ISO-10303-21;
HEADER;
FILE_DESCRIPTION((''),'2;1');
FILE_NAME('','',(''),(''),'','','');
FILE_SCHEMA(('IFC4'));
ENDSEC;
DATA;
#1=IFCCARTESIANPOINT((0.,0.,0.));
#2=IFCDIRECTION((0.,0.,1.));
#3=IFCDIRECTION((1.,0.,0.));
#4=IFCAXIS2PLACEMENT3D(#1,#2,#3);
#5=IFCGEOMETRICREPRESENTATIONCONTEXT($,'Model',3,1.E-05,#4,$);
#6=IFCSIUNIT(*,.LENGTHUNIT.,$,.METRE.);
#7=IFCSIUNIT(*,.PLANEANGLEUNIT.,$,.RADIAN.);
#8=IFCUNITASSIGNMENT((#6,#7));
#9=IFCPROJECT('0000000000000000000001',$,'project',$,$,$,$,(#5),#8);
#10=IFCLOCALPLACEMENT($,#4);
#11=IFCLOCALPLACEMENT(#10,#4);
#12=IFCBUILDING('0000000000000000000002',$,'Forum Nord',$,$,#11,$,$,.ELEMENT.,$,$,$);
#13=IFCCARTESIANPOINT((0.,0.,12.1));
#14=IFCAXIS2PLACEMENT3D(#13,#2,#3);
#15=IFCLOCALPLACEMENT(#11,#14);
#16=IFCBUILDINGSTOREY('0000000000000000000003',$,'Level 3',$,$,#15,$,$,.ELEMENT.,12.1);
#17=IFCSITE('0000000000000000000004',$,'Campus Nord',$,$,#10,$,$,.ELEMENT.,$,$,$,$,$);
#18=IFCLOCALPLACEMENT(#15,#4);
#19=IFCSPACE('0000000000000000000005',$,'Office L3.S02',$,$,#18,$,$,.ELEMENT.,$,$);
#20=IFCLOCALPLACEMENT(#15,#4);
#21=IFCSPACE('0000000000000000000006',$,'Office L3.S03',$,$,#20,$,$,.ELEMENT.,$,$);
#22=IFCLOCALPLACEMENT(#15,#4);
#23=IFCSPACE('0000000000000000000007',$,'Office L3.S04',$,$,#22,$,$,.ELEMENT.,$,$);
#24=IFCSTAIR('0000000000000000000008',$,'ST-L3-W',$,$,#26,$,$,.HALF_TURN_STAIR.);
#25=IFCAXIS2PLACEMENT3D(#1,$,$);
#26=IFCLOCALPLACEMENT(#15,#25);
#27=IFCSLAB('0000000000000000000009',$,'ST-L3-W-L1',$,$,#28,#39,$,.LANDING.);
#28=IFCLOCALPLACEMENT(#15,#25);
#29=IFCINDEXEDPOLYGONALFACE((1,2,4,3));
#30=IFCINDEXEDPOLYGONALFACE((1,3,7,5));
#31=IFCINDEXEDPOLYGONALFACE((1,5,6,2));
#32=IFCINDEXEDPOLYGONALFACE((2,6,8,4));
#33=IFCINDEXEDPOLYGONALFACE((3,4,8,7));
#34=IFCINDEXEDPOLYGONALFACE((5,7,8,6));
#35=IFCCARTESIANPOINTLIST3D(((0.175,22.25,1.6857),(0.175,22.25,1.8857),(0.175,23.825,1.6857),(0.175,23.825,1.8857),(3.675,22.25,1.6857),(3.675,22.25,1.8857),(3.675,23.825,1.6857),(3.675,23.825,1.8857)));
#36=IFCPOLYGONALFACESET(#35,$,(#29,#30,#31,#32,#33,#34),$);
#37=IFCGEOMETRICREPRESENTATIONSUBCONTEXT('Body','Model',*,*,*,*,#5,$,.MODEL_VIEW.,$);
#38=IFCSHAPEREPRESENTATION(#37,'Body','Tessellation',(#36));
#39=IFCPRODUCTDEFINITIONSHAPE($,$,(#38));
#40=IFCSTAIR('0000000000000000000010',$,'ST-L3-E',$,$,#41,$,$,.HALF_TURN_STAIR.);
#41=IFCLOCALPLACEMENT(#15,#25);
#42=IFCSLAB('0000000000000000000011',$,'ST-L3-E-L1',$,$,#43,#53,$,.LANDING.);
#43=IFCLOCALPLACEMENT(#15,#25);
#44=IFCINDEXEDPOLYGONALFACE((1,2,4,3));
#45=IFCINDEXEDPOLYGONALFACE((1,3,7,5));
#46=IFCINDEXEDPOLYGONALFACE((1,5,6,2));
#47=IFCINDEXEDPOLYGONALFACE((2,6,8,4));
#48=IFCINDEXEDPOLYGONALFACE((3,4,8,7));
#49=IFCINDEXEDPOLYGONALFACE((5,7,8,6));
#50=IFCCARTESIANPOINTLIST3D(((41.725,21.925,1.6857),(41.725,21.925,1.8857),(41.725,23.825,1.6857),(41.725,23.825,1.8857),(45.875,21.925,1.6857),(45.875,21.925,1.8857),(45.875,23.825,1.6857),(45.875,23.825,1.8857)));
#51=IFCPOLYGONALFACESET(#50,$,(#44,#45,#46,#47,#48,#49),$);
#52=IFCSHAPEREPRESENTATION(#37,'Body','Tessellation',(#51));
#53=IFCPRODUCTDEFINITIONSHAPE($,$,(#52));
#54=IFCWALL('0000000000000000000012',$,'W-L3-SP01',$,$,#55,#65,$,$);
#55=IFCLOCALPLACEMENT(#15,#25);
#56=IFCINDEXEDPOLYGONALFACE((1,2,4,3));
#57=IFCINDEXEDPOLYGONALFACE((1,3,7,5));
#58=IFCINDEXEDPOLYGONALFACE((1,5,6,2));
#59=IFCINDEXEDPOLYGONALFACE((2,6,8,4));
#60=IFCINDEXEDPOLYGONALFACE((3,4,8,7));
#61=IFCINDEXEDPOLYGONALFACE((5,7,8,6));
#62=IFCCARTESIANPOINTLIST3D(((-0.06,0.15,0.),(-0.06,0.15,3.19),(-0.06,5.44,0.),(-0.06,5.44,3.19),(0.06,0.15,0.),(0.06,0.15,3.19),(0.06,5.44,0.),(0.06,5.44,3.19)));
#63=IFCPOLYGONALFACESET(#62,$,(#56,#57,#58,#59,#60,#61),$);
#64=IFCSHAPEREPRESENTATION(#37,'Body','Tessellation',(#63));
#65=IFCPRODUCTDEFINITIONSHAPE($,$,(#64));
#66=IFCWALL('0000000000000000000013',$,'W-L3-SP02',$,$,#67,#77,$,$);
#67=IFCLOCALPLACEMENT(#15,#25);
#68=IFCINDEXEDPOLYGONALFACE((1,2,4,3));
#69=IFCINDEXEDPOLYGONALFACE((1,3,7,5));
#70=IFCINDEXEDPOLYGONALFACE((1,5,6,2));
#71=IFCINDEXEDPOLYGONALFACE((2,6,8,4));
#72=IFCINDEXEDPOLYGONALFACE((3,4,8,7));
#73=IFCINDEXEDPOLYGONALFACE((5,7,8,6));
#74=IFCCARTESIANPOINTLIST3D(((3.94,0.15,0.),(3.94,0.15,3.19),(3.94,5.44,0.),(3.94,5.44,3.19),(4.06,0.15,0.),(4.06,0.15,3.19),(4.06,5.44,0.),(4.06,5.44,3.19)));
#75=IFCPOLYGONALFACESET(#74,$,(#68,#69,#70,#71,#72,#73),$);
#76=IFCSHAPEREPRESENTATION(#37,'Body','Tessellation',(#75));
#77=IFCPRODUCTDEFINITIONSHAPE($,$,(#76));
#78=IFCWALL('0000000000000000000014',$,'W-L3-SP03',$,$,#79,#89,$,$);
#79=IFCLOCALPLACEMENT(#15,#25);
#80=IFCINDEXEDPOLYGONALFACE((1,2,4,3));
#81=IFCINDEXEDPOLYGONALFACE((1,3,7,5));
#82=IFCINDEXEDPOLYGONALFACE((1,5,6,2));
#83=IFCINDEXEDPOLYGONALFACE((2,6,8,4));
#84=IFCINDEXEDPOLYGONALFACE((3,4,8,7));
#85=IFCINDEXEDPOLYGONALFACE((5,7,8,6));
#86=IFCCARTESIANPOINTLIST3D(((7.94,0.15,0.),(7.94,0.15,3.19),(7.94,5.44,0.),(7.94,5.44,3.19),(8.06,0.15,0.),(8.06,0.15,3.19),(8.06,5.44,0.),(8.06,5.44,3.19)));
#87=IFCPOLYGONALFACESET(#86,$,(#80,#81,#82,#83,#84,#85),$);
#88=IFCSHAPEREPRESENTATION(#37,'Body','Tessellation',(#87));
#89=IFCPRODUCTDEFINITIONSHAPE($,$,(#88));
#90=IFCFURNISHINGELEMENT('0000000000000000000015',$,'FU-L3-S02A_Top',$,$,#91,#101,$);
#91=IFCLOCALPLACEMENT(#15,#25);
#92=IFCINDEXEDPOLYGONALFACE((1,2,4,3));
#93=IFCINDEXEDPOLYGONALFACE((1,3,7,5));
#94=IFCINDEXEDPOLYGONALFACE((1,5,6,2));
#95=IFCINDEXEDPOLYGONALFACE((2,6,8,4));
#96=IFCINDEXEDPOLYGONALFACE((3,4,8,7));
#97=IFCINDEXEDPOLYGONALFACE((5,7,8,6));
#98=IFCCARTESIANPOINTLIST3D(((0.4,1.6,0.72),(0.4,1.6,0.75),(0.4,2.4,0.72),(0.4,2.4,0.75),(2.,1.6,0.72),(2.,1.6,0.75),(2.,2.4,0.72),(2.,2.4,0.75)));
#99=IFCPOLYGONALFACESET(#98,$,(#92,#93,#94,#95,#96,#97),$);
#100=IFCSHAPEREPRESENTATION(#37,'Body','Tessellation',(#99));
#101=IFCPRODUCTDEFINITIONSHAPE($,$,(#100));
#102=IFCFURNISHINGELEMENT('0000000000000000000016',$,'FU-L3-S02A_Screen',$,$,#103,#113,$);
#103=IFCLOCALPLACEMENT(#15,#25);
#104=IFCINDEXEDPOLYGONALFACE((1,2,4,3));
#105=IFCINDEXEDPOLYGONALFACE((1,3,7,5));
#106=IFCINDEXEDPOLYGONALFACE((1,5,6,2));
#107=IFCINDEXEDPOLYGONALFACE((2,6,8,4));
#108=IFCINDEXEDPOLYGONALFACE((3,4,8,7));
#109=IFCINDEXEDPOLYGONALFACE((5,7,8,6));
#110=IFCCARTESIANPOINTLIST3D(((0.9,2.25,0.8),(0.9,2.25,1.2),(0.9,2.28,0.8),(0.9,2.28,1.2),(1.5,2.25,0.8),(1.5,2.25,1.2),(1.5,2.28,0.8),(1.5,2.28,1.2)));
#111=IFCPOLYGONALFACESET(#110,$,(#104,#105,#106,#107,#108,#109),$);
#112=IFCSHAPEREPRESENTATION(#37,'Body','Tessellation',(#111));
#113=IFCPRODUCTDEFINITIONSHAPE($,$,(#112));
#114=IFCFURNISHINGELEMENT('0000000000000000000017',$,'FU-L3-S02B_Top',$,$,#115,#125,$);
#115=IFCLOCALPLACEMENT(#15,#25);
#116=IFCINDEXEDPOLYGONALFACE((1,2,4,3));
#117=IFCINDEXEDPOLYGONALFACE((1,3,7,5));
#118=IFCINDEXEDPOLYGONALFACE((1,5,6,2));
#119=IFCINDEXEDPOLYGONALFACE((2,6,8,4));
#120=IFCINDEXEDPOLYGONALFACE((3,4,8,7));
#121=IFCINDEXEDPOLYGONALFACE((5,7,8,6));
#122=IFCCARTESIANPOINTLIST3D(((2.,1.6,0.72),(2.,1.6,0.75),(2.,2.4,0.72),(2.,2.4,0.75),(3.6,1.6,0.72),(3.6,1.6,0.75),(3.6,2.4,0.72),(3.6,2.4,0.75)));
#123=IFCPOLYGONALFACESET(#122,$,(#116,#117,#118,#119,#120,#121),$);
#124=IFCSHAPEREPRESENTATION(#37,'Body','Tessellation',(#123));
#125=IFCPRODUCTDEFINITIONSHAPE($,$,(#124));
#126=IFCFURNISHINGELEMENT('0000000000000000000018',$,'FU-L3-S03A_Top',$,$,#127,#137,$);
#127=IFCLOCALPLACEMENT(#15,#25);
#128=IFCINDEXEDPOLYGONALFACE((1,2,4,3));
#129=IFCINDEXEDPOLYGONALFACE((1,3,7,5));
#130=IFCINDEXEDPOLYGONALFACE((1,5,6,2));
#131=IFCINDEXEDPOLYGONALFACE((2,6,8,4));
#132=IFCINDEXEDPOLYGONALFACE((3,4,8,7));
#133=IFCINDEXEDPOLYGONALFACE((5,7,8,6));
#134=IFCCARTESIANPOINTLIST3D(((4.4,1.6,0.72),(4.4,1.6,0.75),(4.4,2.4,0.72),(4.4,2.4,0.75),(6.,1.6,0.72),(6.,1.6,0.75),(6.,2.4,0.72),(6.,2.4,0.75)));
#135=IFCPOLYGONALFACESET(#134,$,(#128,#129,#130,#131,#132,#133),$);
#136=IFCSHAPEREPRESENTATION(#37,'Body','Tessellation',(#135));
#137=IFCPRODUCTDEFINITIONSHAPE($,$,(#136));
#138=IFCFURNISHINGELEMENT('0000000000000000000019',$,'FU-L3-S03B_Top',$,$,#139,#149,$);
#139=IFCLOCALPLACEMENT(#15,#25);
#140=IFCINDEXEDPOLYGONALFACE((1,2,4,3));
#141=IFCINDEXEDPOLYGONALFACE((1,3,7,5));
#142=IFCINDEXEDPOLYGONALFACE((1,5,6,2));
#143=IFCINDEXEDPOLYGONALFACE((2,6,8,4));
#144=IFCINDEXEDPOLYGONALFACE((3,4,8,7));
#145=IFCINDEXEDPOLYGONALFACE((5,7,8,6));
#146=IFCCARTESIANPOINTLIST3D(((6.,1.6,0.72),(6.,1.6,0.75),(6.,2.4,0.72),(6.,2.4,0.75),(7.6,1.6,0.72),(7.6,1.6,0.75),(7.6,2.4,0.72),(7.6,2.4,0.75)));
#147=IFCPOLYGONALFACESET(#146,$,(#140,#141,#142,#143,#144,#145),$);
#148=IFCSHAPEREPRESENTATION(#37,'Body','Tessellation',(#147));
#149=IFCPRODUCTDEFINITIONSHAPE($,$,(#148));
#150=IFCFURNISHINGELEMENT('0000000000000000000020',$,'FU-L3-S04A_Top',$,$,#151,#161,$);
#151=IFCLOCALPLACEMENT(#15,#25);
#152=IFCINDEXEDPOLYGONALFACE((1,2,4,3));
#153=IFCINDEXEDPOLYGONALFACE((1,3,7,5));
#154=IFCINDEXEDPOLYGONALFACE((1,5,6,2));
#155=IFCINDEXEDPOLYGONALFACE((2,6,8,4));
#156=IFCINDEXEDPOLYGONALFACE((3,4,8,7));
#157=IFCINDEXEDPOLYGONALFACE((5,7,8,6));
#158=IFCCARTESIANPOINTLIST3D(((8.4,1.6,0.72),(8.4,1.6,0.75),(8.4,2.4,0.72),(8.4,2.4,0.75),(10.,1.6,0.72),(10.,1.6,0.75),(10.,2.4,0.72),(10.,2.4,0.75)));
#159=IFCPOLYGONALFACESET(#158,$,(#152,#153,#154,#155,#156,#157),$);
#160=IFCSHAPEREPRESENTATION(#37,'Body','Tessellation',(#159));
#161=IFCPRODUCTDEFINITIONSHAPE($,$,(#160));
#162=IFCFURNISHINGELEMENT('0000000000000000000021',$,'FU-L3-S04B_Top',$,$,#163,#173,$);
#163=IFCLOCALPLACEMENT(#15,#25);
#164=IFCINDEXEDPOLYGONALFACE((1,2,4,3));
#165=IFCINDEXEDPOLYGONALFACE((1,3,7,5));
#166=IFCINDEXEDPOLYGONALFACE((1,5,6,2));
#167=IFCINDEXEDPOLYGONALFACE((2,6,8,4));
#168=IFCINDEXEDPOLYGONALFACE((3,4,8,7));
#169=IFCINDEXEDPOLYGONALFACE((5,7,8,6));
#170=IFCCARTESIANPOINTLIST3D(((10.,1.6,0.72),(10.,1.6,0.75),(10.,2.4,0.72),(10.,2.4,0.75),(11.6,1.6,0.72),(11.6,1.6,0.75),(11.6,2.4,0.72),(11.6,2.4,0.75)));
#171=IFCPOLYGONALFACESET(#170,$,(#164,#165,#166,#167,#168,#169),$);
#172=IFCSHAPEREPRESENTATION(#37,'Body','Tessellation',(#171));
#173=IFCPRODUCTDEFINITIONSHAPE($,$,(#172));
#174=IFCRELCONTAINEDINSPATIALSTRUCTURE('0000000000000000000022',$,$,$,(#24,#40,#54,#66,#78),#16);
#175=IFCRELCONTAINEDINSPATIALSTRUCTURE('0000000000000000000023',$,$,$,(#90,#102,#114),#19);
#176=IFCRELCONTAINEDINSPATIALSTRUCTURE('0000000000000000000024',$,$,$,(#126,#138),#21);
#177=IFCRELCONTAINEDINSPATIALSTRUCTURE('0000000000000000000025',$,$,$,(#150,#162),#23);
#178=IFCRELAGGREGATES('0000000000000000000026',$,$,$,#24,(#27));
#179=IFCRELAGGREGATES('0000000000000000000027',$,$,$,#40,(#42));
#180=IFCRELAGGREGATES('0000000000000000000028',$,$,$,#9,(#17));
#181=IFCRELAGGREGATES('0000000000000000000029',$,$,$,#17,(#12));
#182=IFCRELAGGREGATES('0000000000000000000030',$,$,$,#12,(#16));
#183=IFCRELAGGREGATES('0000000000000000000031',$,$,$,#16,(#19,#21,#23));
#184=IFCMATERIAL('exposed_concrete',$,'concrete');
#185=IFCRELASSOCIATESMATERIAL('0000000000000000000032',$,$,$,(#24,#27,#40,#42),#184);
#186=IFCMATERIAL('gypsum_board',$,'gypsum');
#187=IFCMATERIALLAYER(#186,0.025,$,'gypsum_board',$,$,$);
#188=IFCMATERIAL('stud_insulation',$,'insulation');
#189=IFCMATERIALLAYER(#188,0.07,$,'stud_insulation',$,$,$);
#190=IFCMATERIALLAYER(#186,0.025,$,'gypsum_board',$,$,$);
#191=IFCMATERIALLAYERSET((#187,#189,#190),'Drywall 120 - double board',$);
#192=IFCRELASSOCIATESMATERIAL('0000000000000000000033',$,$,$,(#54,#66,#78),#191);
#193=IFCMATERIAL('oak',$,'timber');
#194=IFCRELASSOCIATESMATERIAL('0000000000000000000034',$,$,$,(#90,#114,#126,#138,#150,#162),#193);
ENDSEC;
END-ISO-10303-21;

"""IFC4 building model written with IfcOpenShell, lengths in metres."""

from ifc_helpers import new_model, si_unit, frame, frame_2d, origin_with_axes, place, context, subcontext, project, spatial, polyline, rectangle, outline, extrude, material, layer, layer_set, layer_usage, element, aggregate, save


model = new_model("IFC4")

# Units and contexts
model_context = context("Model", 3, precision=1e-05, world=origin_with_axes())
body_context = subcontext(model_context, "Body", "Model", "MODEL_VIEW")
ifc_project = project(units=[si_unit("LENGTHUNIT", "METRE"), si_unit("PLANEANGLEUNIT", "RADIAN")], contexts=[model_context])

# Site, building, storey
site_placement = place(None, origin_with_axes())
site = spatial("IfcSite", under=ifc_project, at=site_placement, Name="Campus Nord", CompositionType="ELEMENT")
building_placement = place(site_placement, origin_with_axes())
building = spatial("IfcBuilding", under=site, at=building_placement, Name="Forum Nord", CompositionType="ELEMENT")
storey_placement = place(building_placement, frame((0.0, 0.0, 12.1), z_axis=(0.0, 0.0, 1.0), x_axis=(1.0, 0.0, 0.0)))
storey = spatial("IfcBuildingStorey", under=building, at=storey_placement, Name="Level 3", CompositionType="ELEMENT", Elevation=12.1)

# Stairs, slabs
ifc_material_1 = material(Name="exposed_concrete", Category="concrete")
stair_1_placement = place(storey_placement, origin_with_axes())
stair_1 = element("IfcStair", 1, at=stair_1_placement, inside=storey, material=ifc_material_1, Name="ST-L3-W", PredefinedType="HALF_TURN_STAIR")
slab_1_placement = place(storey_placement, frame((0.0, 0.0, 1.8857), z_axis=(0.0, 0.0, 1.0), x_axis=(1.0, 0.0, 0.0)))
slab_1 = element("IfcSlab", 2, at=slab_1_placement, material=ifc_material_1, Name="ST-L3-W-L1", PredefinedType="LANDING", context=body_context, shape_type="SweptSolid", body=[
    extrude(outline(polyline([(0.175, 22.25), (3.675, 22.25), (3.675, 23.825), (0.175, 23.825), (0.175, 22.25)])), frame((0.0, 0.0, -0.2), z_axis=(0.0, 0.0, 1.0), x_axis=(1.0, 0.0, 0.0)), (0.0, 0.0, 1.0), 0.2),
])
aggregate(stair_1, [slab_1])
stair_2_placement = place(storey_placement, origin_with_axes())
stair_2 = element("IfcStair", 3, at=stair_2_placement, inside=storey, material=ifc_material_1, Name="ST-L3-E", PredefinedType="HALF_TURN_STAIR")
slab_2_placement = place(storey_placement, frame((0.0, 0.0, 1.8857), z_axis=(0.0, 0.0, 1.0), x_axis=(1.0, 0.0, 0.0)))
slab_2 = element("IfcSlab", 4, at=slab_2_placement, material=ifc_material_1, Name="ST-L3-E-L1", PredefinedType="LANDING", context=body_context, shape_type="SweptSolid", body=[
    extrude(outline(polyline([(41.725, 21.925), (45.875, 21.925), (45.875, 23.825), (41.725, 23.825), (41.725, 21.925)])), frame((0.0, 0.0, -0.2), z_axis=(0.0, 0.0, 1.0), x_axis=(1.0, 0.0, 0.0)), (0.0, 0.0, 1.0), 0.2),
])
aggregate(stair_2, [slab_2])

# Walls
ifc_material_2 = material(Name="gypsum_board", Category="gypsum")
ifc_layer_1 = layer(ifc_material_2, 0.025, Name="gypsum_board")
ifc_material_3 = material(Name="stud_insulation", Category="insulation")
ifc_layer_2 = layer(ifc_material_3, 0.07, Name="stud_insulation")
ifc_layer_3 = layer(ifc_material_2, 0.025, Name="gypsum_board")
ifc_layer_set = layer_set([ifc_layer_1, ifc_layer_2, ifc_layer_3], Name="Drywall 120 - double board")
ifc_layer_usage = layer_usage(ifc_layer_set, "AXIS2", "POSITIVE", -0.06)
for number, where, z_axis, x_axis, name in (
    (5, (0.0, 0.15, 0.0), (0.0, 0.0, 1.0), (0.0, 1.0, 0.0), "W-L3-SP01"),
    (6, (4.0, 0.15, 0.0), (0.0, 0.0, 1.0), (0.0, 1.0, 0.0), "W-L3-SP02"),
    (7, (8.0, 0.15, 0.0), (0.0, 0.0, 1.0), (0.0, 1.0, 0.0), "W-L3-SP03"),
):
    element("IfcWall", number, at=place(storey_placement, frame(where, z_axis=z_axis, x_axis=x_axis)), inside=storey, material=ifc_layer_usage, Name=name, context=body_context, shape_type="SweptSolid", body=[
        extrude(outline(polyline([(0.0, -0.06), (5.29, -0.06), (5.29, 0.06), (0.0, 0.06), (0.0, -0.06)])), origin_with_axes(), (0.0, 0.0, 1.0), 3.19),
    ])

# Shared definitions
space_1_placement = place(storey_placement, origin_with_axes())
space_1 = spatial("IfcSpace", under=storey, at=space_1_placement, Name="Office L3.S02", CompositionType="ELEMENT")

# Furnishing elements
ifc_material_4 = material(Name="oak", Category="timber")
furnishing_1_placement = place(storey_placement, frame((0.4, 1.0, 0.0), z_axis=(0.0, 0.0, 1.0), x_axis=(1.0, 0.0, 0.0)))
element("IfcFurnishingElement", 8, at=furnishing_1_placement, inside=space_1, material=ifc_material_4, Name="FU-L3-S02A_Top", context=body_context, shape_type="SweptSolid", body=[
    extrude(rectangle(XDim=1.6, YDim=0.8, at=frame_2d((0.8, 1.0), x_axis=(1.0, 0.0))), frame((0.0, 0.0, 0.72), z_axis=(0.0, 0.0, 1.0), x_axis=(1.0, 0.0, 0.0)), (0.0, 0.0, 1.0), 0.03),
])
furnishing_2_placement = place(storey_placement, frame((0.4, 1.0, 0.0), z_axis=(0.0, 0.0, 1.0), x_axis=(1.0, 0.0, 0.0)))
element("IfcFurnishingElement", 9, at=furnishing_2_placement, inside=space_1, Name="FU-L3-S02A_Screen", context=body_context, shape_type="SweptSolid", body=[
    extrude(rectangle(XDim=0.6, YDim=0.03, at=frame_2d((0.8, 1.265), x_axis=(1.0, 0.0))), frame((0.0, 0.0, 0.8), z_axis=(0.0, 0.0, 1.0), x_axis=(1.0, 0.0, 0.0)), (0.0, 0.0, 1.0), 0.4),
])
furnishing_3_placement = place(storey_placement, frame((2.0, 1.0, 0.0), z_axis=(0.0, 0.0, 1.0), x_axis=(1.0, 0.0, 0.0)))
element("IfcFurnishingElement", 10, at=furnishing_3_placement, inside=space_1, material=ifc_material_4, Name="FU-L3-S02B_Top", context=body_context, shape_type="SweptSolid", body=[
    extrude(rectangle(XDim=1.6, YDim=0.8, at=frame_2d((0.8, 1.0), x_axis=(1.0, 0.0))), frame((0.0, 0.0, 0.72), z_axis=(0.0, 0.0, 1.0), x_axis=(1.0, 0.0, 0.0)), (0.0, 0.0, 1.0), 0.03),
])

# Shared definitions
space_2_placement = place(storey_placement, origin_with_axes())
space_2 = spatial("IfcSpace", under=storey, at=space_2_placement, Name="Office L3.S03", CompositionType="ELEMENT")

# Furnishing elements
furnishing_4_placement = place(storey_placement, frame((4.4, 1.0, 0.0), z_axis=(0.0, 0.0, 1.0), x_axis=(1.0, 0.0, 0.0)))
element("IfcFurnishingElement", 11, at=furnishing_4_placement, inside=space_2, material=ifc_material_4, Name="FU-L3-S03A_Top", context=body_context, shape_type="SweptSolid", body=[
    extrude(rectangle(XDim=1.6, YDim=0.8, at=frame_2d((0.8, 1.0), x_axis=(1.0, 0.0))), frame((0.0, 0.0, 0.72), z_axis=(0.0, 0.0, 1.0), x_axis=(1.0, 0.0, 0.0)), (0.0, 0.0, 1.0), 0.03),
])
furnishing_5_placement = place(storey_placement, frame((6.0, 1.0, 0.0), z_axis=(0.0, 0.0, 1.0), x_axis=(1.0, 0.0, 0.0)))
element("IfcFurnishingElement", 12, at=furnishing_5_placement, inside=space_2, material=ifc_material_4, Name="FU-L3-S03B_Top", context=body_context, shape_type="SweptSolid", body=[
    extrude(rectangle(XDim=1.6, YDim=0.8, at=frame_2d((0.8, 1.0), x_axis=(1.0, 0.0))), frame((0.0, 0.0, 0.72), z_axis=(0.0, 0.0, 1.0), x_axis=(1.0, 0.0, 0.0)), (0.0, 0.0, 1.0), 0.03),
])

# Shared definitions
space_3_placement = place(storey_placement, origin_with_axes())
space_3 = spatial("IfcSpace", under=storey, at=space_3_placement, Name="Office L3.S04", CompositionType="ELEMENT")

# Furnishing elements
furnishing_6_placement = place(storey_placement, frame((8.4, 1.0, 0.0), z_axis=(0.0, 0.0, 1.0), x_axis=(1.0, 0.0, 0.0)))
element("IfcFurnishingElement", 13, at=furnishing_6_placement, inside=space_3, material=ifc_material_4, Name="FU-L3-S04A_Top", context=body_context, shape_type="SweptSolid", body=[
    extrude(rectangle(XDim=1.6, YDim=0.8, at=frame_2d((0.8, 1.0), x_axis=(1.0, 0.0))), frame((0.0, 0.0, 0.72), z_axis=(0.0, 0.0, 1.0), x_axis=(1.0, 0.0, 0.0)), (0.0, 0.0, 1.0), 0.03),
])
furnishing_7_placement = place(storey_placement, frame((10.0, 1.0, 0.0), z_axis=(0.0, 0.0, 1.0), x_axis=(1.0, 0.0, 0.0)))
element("IfcFurnishingElement", 14, at=furnishing_7_placement, inside=space_3, material=ifc_material_4, Name="FU-L3-S04B_Top", context=body_context, shape_type="SweptSolid", body=[
    extrude(rectangle(XDim=1.6, YDim=0.8, at=frame_2d((0.8, 1.0), x_axis=(1.0, 0.0))), frame((0.0, 0.0, 0.72), z_axis=(0.0, 0.0, 1.0), x_axis=(1.0, 0.0, 0.0)), (0.0, 0.0, 1.0), 0.03),
])

save(model, "model.ifc")
